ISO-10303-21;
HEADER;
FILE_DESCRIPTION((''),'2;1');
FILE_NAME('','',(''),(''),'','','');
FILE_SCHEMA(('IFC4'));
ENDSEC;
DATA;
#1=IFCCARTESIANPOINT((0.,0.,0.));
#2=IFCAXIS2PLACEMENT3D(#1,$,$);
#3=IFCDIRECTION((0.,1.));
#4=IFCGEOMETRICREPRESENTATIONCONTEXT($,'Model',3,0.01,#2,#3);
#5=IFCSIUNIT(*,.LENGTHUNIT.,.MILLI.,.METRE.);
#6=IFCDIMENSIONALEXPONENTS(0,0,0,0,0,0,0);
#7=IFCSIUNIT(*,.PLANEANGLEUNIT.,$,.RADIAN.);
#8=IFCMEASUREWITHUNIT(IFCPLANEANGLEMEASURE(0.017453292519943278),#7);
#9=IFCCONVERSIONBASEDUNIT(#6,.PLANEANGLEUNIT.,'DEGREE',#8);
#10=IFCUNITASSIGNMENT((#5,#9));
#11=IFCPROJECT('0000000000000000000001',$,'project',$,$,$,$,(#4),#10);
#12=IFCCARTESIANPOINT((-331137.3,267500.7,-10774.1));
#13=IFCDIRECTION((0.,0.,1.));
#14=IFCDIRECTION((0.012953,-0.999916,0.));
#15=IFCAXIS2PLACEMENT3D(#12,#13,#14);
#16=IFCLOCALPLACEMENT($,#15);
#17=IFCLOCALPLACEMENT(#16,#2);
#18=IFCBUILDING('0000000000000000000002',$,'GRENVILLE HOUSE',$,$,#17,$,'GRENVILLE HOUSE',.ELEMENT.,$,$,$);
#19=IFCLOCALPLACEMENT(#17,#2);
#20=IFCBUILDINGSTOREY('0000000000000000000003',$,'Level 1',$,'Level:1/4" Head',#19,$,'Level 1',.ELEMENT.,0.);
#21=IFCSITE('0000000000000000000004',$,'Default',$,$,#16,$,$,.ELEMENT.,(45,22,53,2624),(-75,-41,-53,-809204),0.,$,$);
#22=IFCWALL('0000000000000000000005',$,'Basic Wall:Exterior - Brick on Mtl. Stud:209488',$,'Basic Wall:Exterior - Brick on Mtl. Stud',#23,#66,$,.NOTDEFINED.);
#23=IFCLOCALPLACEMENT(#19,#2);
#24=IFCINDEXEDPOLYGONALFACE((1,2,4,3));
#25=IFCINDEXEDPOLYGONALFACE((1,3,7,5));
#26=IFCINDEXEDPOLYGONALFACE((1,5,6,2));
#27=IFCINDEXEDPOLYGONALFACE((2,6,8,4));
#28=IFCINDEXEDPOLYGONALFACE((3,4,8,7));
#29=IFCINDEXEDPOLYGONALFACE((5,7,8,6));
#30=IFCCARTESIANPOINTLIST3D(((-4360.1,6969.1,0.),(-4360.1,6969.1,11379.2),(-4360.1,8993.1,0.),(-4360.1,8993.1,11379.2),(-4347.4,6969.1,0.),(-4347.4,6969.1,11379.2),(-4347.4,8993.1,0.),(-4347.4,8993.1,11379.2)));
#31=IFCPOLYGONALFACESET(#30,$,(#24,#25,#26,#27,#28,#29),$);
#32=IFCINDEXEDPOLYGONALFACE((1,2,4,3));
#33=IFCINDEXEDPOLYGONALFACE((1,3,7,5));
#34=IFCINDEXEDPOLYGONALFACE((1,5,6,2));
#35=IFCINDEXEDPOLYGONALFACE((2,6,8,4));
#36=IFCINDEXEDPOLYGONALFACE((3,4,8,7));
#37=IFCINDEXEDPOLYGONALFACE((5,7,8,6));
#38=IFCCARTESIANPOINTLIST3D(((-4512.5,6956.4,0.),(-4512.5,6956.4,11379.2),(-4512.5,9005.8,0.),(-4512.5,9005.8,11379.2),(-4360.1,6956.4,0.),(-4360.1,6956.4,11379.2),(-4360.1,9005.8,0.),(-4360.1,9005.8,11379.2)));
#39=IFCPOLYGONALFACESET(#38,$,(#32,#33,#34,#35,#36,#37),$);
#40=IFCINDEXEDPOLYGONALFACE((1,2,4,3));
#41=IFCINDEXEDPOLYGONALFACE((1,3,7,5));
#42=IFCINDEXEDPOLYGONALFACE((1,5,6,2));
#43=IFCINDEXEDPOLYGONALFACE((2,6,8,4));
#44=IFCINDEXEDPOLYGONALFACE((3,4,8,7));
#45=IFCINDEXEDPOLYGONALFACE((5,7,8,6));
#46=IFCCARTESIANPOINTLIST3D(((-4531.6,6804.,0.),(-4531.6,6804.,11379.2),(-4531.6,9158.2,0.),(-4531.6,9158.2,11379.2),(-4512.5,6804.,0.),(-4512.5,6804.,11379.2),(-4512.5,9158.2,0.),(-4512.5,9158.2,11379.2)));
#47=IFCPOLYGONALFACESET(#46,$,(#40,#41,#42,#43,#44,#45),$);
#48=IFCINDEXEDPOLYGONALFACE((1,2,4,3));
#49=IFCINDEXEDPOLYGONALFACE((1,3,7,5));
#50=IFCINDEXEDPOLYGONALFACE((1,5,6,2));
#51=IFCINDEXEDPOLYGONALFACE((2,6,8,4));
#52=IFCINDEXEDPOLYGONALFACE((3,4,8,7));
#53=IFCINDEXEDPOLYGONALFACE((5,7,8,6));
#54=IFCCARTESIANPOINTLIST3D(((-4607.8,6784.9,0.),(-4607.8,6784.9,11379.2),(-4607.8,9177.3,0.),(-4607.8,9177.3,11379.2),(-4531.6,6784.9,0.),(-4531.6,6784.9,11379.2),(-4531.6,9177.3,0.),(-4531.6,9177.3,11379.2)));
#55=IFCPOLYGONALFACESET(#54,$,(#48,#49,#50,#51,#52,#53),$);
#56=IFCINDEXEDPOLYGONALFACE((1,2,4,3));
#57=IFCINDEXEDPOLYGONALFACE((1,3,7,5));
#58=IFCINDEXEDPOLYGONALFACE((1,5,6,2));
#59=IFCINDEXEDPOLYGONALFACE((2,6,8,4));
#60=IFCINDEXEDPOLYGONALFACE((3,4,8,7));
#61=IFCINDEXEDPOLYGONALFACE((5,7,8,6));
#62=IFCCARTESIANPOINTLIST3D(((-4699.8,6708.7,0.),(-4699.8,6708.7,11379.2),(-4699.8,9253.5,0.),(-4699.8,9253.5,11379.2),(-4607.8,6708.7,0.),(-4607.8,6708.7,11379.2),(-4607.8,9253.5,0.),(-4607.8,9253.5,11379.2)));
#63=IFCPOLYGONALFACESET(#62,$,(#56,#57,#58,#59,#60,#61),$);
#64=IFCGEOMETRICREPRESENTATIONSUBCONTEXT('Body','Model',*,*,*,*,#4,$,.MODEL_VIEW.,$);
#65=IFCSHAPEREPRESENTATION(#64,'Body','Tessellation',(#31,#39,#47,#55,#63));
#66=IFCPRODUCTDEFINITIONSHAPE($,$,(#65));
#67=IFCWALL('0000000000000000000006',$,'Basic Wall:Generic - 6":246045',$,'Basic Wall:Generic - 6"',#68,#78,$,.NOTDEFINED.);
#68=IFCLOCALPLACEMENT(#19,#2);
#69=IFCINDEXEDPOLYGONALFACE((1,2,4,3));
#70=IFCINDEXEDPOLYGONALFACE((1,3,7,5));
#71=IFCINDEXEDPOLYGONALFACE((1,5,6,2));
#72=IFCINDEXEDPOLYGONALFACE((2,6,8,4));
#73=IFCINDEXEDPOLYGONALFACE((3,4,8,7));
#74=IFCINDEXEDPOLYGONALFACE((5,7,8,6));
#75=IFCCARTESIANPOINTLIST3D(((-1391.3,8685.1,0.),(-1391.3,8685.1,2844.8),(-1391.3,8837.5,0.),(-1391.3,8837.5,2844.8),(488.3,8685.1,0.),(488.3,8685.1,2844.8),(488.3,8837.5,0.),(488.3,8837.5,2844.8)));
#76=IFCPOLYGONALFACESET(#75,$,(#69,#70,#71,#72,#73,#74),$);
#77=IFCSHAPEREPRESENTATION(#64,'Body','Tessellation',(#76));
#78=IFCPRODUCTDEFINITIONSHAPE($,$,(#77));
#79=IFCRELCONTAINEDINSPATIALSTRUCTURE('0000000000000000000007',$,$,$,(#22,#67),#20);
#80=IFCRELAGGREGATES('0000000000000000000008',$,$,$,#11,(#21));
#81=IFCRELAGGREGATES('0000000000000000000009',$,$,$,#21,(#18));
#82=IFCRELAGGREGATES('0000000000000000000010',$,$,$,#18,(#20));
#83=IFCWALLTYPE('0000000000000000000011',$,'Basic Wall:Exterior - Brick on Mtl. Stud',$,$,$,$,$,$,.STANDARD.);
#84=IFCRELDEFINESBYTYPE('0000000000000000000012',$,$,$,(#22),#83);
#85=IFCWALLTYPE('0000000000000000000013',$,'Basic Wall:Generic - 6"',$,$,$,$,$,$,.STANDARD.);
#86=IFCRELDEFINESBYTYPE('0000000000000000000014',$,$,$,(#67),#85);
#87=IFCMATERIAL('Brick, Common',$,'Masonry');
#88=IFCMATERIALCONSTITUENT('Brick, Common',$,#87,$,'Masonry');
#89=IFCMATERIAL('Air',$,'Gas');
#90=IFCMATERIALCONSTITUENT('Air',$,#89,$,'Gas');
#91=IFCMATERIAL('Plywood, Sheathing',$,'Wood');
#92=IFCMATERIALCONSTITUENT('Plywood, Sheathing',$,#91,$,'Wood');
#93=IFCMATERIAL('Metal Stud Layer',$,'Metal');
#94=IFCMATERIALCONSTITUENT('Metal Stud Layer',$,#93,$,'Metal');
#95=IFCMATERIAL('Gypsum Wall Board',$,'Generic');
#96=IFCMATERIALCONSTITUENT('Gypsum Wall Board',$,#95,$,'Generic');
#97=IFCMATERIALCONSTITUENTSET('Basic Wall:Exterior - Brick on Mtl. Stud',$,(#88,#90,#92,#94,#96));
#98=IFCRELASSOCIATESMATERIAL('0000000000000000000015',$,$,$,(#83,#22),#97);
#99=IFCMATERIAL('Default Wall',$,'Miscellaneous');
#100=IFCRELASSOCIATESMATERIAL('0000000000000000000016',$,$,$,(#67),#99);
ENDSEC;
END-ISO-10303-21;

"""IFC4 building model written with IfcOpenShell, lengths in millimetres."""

from ifc_helpers import new_model, entity, si_unit, converted_unit, direction, frame, origin, place, context, subcontext, project, spatial, indexed_curve, outline, extrude, material, constituent, constituent_set, type_object, element, save


model = new_model("IFC4")

# Units and contexts
model_context = context("Model", 3, precision=0.01, world=origin(), true_north=direction((0.0, 1.0)))
body_context = subcontext(model_context, "Body", "Model", "MODEL_VIEW")
ifc_project = project(units=[si_unit("LENGTHUNIT", "METRE", prefix="MILLI"), converted_unit("PLANEANGLEUNIT", "DEGREE", entity("IfcPlaneAngleMeasure", 0.017453292519943278), si_unit("PLANEANGLEUNIT", "RADIAN"), dimensions=[0, 0, 0, 0, 0, 0, 0])], contexts=[model_context])

# Site, building, storey
site_placement = place(None, frame((-331137.3, 267500.7, -10774.1), z_axis=(0.0, 0.0, 1.0), x_axis=(0.012953, -0.999916, 0.0)))
site = spatial("IfcSite", under=ifc_project, at=site_placement, Name="Default", CompositionType="ELEMENT", RefLatitude=(45, 22, 53, 2624), RefLongitude=(-75, -41, -53, -809204), RefElevation=0.0)
building_placement = place(site_placement, origin())
building = spatial("IfcBuilding", under=site, at=building_placement, Name="GRENVILLE HOUSE", LongName="GRENVILLE HOUSE", CompositionType="ELEMENT")
storey_placement = place(building_placement, origin())
storey = spatial("IfcBuildingStorey", under=building, at=storey_placement, Name="Level 1", ObjectType="Level:1/4\" Head", LongName="Level 1", CompositionType="ELEMENT", Elevation=0.0)

# Walls
ifc_material_1 = material(Name="Brick, Common", Category="Masonry")
ifc_constituent_1 = constituent(ifc_material_1, Name="Brick, Common", Category="Masonry")
ifc_material_2 = material(Name="Air", Category="Gas")
ifc_constituent_2 = constituent(ifc_material_2, Name="Air", Category="Gas")
ifc_material_3 = material(Name="Plywood, Sheathing", Category="Wood")
ifc_constituent_3 = constituent(ifc_material_3, Name="Plywood, Sheathing", Category="Wood")
ifc_material_4 = material(Name="Metal Stud Layer", Category="Metal")
ifc_constituent_4 = constituent(ifc_material_4, Name="Metal Stud Layer", Category="Metal")
ifc_material_5 = material(Name="Gypsum Wall Board", Category="Generic")
ifc_constituent_5 = constituent(ifc_material_5, Name="Gypsum Wall Board", Category="Generic")
ifc_constituent_set_1 = constituent_set(constituents=[ifc_constituent_1, ifc_constituent_2, ifc_constituent_3, ifc_constituent_4, ifc_constituent_5], Name="Basic Wall:Exterior - Brick on Mtl. Stud")
wall_type_1 = type_object("IfcWallType", Name="Basic Wall:Exterior - Brick on Mtl. Stud", PredefinedType="STANDARD", material=ifc_constituent_set_1)
wall_1_placement = place(storey_placement, frame((-4523.6, 6969.1, 0.0), z_axis=(0.0, 0.0, 1.0), x_axis=(0.0, 1.0, 0.0)))
element("IfcWall", 1, at=wall_1_placement, inside=storey, type_object=wall_type_1, material=ifc_constituent_set_1, Name="Basic Wall:Exterior - Brick on Mtl. Stud:209488", ObjectType="Basic Wall:Exterior - Brick on Mtl. Stud", PredefinedType="NOTDEFINED", context=body_context, shape_type="SweptSolid", body=[
    extrude(outline(indexed_curve([(-6.4, -1012.0), (6.3, -1012.0), (6.4, 1012.0), (-6.3, 1012.0), (-6.4, -1012.0)], self_intersect=False)), frame((1012.0, -169.9, 0.0), z_axis=(0.0, 0.0, 1.0), x_axis=(0.0, 1.0, 0.0)), (0.0, 0.0, 1.0), 11379.2),
    extrude(outline(indexed_curve([(-1024.7, -76.2), (1024.7, -76.2), (1024.7, 76.2), (-1024.7, 76.2), (-1024.7, -76.2)], self_intersect=False)), frame((1012.0, -87.3, 0.0)), (0.0, 0.0, 1.0), 11379.2),
    extrude(outline(indexed_curve([(-1177.1, -9.5), (1177.1, -9.5), (1177.1, 9.5), (-1177.1, 9.5), (-1177.1, -9.5)], self_intersect=False)), frame((1012.0, -1.6, 0.0)), (0.0, 0.0, 1.0), 11379.2),
    extrude(outline(indexed_curve([(-1196.2, -38.1), (1196.2, -38.1), (1196.2, 38.1), (-1196.2, 38.1), (-1196.2, -38.1)], self_intersect=False)), frame((1012.0, 46.0, 0.0)), (0.0, 0.0, 1.0), 11379.2),
    extrude(outline(indexed_curve([(-46.0, -1272.4), (46.0, -1272.4), (46.0, 1272.4), (-46.0, 1272.4), (-46.0, -1272.4)], self_intersect=False)), frame((1012.0, 130.2, 0.0), z_axis=(0.0, 0.0, 1.0), x_axis=(0.0, -1.0, 0.0)), (0.0, 0.0, 1.0), 11379.2),
])
ifc_material_6 = material(Name="Default Wall", Category="Miscellaneous")
wall_type_2 = type_object("IfcWallType", Name="Basic Wall:Generic - 6\"", PredefinedType="STANDARD")
wall_2_placement = place(storey_placement, frame((488.3, 8761.3, 0.0), z_axis=(0.0, 0.0, 1.0), x_axis=(-1.0, 0.0, 0.0)))
element("IfcWall", 2, at=wall_2_placement, inside=storey, type_object=wall_type_2, material=ifc_material_6, Name="Basic Wall:Generic - 6\":246045", ObjectType="Basic Wall:Generic - 6\"", PredefinedType="NOTDEFINED", context=body_context, shape_type="SweptSolid", body=[
    extrude(outline(indexed_curve([(1879.6, 76.2), (0.0, 76.2), (0.0, -76.2), (1879.6, -76.2), (1879.6, 76.2)], self_intersect=False)), origin(), (0.0, 0.0, 1.0), 2844.8),
])

save(model, "model.ifc")
